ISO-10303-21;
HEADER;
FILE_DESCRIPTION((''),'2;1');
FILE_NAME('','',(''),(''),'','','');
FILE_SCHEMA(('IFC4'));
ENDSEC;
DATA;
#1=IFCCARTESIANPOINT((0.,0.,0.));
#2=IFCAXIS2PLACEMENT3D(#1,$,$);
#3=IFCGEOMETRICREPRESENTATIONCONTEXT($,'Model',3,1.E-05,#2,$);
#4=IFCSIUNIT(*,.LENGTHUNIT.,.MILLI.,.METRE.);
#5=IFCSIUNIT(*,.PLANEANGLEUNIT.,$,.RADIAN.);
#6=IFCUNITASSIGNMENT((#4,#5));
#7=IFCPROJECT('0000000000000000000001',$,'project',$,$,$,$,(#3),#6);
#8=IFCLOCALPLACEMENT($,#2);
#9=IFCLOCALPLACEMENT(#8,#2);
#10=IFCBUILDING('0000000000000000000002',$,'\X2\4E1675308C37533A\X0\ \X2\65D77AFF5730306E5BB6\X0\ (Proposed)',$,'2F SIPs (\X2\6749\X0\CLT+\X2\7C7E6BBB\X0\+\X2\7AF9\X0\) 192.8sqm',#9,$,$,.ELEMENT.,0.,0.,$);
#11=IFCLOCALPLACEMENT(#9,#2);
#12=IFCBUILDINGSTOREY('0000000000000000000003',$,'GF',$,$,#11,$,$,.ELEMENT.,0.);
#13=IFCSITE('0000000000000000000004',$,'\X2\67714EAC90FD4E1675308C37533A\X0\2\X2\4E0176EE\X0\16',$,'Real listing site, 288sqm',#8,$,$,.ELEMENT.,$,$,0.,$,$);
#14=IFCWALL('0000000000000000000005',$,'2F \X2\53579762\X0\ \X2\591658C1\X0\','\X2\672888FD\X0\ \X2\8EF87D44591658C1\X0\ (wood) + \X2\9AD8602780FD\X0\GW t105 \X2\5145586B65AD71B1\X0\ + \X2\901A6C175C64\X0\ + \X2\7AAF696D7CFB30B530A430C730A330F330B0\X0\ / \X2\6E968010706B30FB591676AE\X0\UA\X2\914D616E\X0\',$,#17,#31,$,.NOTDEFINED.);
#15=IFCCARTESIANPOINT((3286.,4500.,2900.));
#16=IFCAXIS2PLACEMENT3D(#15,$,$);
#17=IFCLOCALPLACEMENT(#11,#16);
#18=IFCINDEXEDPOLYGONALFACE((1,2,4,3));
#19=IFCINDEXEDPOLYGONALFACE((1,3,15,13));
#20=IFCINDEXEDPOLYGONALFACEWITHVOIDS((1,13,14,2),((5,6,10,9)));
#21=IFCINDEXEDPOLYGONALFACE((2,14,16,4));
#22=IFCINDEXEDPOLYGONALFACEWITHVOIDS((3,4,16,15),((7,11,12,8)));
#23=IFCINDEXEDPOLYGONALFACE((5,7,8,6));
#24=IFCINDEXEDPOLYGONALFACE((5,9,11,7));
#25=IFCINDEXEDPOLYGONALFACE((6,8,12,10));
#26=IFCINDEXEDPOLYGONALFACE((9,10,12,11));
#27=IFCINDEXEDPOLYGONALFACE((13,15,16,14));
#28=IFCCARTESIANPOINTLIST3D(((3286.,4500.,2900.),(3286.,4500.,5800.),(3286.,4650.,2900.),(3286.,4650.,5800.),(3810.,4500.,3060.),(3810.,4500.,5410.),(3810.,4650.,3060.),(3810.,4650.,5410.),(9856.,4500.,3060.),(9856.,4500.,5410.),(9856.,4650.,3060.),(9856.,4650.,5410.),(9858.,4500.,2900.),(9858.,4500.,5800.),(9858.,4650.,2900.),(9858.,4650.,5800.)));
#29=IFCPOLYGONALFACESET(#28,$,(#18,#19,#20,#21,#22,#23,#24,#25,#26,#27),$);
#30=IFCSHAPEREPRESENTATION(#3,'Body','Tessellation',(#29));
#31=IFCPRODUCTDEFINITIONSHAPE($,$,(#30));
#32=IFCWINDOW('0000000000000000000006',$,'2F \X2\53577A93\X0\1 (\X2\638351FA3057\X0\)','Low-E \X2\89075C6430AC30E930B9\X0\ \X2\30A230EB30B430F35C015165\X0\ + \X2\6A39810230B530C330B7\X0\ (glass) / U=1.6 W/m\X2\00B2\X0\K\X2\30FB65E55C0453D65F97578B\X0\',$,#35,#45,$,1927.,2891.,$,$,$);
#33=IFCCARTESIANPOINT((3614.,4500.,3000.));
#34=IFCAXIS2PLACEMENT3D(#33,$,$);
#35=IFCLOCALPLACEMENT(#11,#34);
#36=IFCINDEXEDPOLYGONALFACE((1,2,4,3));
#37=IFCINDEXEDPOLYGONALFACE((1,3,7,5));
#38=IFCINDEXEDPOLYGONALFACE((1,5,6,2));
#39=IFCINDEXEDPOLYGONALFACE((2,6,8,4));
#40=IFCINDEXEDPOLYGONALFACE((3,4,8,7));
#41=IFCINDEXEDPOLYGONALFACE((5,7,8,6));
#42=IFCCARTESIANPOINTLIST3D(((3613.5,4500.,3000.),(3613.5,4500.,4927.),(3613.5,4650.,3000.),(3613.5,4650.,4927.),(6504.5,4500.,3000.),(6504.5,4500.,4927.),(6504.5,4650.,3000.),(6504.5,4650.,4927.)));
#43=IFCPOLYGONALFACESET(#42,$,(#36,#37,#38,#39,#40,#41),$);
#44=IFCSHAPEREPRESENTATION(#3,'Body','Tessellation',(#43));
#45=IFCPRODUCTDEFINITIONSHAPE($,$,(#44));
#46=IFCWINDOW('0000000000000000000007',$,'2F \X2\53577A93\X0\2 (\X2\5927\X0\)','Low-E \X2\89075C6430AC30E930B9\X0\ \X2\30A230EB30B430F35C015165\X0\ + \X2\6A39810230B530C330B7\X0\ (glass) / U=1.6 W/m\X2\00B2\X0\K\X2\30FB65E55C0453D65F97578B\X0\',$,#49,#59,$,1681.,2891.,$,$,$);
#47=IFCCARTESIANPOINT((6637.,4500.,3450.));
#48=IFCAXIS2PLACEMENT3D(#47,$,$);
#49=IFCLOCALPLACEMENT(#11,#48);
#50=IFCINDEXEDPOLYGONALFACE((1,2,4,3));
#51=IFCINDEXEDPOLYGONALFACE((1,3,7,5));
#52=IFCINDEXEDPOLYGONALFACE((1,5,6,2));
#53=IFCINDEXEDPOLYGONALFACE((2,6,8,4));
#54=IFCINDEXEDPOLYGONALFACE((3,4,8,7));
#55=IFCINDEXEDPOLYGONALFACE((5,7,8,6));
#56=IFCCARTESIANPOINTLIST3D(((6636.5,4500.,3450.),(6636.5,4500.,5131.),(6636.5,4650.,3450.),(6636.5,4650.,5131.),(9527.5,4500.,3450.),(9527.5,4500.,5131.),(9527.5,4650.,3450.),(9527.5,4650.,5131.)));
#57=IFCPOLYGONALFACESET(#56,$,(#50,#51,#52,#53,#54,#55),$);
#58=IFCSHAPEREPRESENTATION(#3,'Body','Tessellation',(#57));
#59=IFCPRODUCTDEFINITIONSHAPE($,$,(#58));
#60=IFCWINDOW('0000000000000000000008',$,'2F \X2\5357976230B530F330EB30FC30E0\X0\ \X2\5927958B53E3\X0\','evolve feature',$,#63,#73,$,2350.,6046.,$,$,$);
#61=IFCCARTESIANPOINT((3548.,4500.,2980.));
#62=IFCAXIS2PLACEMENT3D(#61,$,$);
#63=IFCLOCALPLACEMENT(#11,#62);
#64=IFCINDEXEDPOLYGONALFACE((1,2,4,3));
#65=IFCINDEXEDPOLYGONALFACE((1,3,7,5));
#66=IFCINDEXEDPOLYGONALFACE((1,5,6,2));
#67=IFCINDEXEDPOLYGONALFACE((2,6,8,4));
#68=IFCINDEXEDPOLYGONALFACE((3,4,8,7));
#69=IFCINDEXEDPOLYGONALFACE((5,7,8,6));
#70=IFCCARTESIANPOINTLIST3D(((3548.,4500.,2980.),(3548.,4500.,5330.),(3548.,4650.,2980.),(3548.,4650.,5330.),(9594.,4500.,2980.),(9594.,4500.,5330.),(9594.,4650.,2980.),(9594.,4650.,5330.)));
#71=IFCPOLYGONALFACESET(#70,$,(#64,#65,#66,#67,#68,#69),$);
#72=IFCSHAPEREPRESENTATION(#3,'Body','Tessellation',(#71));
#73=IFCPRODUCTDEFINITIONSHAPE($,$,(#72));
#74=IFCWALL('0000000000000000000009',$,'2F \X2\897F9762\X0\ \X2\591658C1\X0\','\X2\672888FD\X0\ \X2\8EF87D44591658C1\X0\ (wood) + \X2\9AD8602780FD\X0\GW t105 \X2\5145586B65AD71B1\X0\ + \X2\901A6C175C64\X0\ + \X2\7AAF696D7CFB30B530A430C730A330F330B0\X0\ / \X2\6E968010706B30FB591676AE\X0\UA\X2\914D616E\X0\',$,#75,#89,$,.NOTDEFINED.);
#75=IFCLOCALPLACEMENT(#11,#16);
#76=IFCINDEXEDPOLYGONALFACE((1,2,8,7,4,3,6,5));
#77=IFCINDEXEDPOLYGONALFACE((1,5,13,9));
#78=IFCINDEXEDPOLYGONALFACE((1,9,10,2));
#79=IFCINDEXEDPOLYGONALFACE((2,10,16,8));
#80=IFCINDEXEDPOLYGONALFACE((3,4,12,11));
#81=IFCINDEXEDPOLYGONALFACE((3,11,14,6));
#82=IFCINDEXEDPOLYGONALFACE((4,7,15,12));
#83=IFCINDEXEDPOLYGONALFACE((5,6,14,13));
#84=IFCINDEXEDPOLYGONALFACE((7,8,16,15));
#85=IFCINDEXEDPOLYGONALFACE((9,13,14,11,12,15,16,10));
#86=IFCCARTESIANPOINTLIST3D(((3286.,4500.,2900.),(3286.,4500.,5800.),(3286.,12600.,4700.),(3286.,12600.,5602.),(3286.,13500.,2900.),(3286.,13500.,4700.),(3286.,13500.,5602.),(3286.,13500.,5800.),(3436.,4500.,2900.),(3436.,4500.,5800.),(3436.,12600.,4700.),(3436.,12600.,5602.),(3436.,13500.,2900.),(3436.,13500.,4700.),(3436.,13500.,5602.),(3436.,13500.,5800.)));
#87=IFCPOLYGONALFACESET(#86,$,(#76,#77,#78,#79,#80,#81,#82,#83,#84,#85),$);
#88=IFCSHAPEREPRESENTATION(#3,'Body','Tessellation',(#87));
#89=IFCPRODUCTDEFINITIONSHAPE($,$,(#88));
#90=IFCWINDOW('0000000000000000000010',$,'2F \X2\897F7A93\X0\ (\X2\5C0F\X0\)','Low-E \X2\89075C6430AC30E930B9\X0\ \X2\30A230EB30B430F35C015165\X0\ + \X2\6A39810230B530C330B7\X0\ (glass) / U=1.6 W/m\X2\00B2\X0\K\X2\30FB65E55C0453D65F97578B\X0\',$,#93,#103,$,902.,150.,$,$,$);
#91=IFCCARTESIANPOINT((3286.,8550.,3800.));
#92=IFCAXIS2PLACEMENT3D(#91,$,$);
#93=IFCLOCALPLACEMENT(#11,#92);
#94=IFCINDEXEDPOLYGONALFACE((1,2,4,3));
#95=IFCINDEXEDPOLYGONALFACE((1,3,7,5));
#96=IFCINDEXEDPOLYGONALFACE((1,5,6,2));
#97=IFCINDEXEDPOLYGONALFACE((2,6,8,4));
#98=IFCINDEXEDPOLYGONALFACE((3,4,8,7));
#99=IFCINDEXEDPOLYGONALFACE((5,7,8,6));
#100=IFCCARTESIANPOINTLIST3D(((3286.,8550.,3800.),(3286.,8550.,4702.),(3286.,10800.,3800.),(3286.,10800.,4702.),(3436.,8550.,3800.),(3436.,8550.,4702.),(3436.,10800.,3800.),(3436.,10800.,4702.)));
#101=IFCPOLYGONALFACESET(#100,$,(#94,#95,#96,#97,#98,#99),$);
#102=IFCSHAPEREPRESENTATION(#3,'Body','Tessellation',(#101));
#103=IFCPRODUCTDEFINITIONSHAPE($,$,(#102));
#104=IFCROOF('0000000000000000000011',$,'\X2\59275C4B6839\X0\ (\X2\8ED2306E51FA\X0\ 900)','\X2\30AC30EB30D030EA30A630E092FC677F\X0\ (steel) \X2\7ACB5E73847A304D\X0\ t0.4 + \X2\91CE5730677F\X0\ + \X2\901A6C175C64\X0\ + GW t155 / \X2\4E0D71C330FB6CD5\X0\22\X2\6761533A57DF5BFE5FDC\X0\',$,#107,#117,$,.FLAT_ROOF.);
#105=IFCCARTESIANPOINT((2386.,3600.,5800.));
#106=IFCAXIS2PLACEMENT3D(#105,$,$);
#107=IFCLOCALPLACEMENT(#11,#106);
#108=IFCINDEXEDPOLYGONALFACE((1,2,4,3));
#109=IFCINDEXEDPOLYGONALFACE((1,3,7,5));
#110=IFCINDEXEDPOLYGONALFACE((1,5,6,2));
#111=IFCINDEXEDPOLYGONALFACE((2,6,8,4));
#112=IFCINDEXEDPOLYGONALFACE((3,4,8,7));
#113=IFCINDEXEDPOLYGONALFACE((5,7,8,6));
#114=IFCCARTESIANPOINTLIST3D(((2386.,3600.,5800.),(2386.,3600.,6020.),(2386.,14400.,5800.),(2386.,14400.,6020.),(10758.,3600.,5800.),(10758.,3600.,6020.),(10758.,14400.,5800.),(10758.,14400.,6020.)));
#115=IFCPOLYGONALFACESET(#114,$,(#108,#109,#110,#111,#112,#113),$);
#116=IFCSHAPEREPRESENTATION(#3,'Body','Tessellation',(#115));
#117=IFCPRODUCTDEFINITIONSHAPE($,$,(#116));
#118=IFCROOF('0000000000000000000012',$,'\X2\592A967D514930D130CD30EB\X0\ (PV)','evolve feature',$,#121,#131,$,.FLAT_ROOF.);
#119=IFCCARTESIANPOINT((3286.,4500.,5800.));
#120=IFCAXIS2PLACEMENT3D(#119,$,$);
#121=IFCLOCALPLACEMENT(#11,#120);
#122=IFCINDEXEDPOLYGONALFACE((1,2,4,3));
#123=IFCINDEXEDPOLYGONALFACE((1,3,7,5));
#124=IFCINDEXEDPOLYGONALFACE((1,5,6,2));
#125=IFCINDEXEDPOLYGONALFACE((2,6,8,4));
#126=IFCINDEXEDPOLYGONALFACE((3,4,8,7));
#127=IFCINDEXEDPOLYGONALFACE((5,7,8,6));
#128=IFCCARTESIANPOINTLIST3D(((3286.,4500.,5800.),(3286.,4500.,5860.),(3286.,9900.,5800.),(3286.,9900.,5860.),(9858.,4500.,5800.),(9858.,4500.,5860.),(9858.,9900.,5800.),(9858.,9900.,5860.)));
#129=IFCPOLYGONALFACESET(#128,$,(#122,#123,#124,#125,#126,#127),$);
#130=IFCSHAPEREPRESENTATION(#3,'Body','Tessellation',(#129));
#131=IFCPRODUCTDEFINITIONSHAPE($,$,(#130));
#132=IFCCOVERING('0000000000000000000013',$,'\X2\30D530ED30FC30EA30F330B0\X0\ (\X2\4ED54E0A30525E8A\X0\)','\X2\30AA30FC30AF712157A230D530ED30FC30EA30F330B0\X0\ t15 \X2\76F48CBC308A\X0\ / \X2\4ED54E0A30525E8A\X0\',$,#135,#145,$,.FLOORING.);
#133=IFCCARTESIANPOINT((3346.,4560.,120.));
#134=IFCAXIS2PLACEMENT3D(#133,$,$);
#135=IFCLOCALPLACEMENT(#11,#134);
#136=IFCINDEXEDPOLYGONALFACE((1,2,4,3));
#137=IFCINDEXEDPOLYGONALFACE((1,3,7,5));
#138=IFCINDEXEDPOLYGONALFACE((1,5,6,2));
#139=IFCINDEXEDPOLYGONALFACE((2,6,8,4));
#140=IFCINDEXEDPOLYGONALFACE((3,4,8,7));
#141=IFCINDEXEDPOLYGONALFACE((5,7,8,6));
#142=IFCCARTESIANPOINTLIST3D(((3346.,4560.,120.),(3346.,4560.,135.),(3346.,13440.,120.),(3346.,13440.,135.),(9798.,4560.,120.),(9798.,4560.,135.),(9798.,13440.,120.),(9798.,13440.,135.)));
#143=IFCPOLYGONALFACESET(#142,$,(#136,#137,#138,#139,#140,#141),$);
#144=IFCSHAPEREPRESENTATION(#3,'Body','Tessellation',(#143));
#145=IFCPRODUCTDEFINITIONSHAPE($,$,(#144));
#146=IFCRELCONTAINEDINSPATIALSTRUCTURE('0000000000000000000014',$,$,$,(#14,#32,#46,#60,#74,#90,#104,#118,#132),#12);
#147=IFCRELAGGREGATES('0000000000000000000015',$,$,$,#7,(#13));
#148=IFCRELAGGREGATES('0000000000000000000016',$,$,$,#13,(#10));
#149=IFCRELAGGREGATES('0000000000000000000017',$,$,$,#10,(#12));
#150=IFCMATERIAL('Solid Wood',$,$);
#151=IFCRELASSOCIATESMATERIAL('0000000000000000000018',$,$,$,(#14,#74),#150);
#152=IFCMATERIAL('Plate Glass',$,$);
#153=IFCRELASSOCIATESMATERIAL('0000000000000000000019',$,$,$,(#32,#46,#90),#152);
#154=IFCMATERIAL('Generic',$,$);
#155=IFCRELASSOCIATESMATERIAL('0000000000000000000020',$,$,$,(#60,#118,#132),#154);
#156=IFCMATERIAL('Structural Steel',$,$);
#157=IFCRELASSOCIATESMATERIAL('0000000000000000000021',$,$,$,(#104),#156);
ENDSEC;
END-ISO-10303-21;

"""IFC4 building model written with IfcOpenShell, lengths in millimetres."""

from ifc_helpers import new_model, si_unit, frame, frame_2d, origin, place, context, project, spatial, rectangle, extrude, material, element, fill, save


model = new_model("IFC4")

# Units and contexts
model_context = context("Model", 3, precision=1e-05, world=origin())
ifc_project = project(units=[si_unit("LENGTHUNIT", "METRE", prefix="MILLI"), si_unit("PLANEANGLEUNIT", "RADIAN")], contexts=[model_context])

# Site, building, storey
site_placement = place(None, origin())
site = spatial("IfcSite", under=ifc_project, at=site_placement, Name="東京都世田谷区2丁目16", ObjectType="Real listing site, 288sqm", CompositionType="ELEMENT", RefElevation=0.0)
building_placement = place(site_placement, origin())
building = spatial("IfcBuilding", under=site, at=building_placement, Name="世田谷区 旗竿地の家 (Proposed)", ObjectType="2F SIPs (杉CLT+籾殻+竹) 192.8sqm", CompositionType="ELEMENT", ElevationOfRefHeight=0.0, ElevationOfTerrain=0.0)
storey_placement = place(building_placement, origin())
storey = spatial("IfcBuildingStorey", under=building, at=storey_placement, Name="GF", CompositionType="ELEMENT", Elevation=0.0)

# Shared definitions
ifc_material_1 = material(Name="Solid Wood")

# Shared definitions
ifc_material_2 = material(Name="Plate Glass")
ifc_material_3 = material(Name="Generic")

# Wall, openings, windows
wall_1_placement = place(storey_placement, frame((3286.0, 4500.0, 2900.0)))
wall_1 = element("IfcWall", 1, at=wall_1_placement, inside=storey, material=ifc_material_1, Name="2F 南面 外壁", Description="木製 軸組外壁 (wood) + 高性能GW t105 充填断熱 + 通気層 + 窯業系サイディング / 準耐火・外皮UA配慮", PredefinedType="NOTDEFINED", context=model_context, shape_type="SweptSolid", body=[
    extrude(rectangle(XDim=6572.0, YDim=150.0, at=frame_2d((3286.0, 75.0))), frame((3286.0, 4500.0, 2900.0)), (0.0, 0.0, 1.0), 2900.0),
])
opening_1_placement = place(storey_placement, frame((3614.0, 4500.0, 3000.0)))
opening_1 = element("IfcOpeningElement", 2, at=opening_1_placement, cuts=wall_1, PredefinedType="NOTDEFINED", context=model_context, shape_type="SweptSolid", body=[
    extrude(rectangle(XDim=2891.0, YDim=150.0, at=frame_2d((1445.0, 75.0))), frame((3614.0, 4500.0, 3000.0)), (0.0, 0.0, 1.0), 1927.0),
])
opening_2_placement = place(storey_placement, frame((6637.0, 4500.0, 3450.0)))
opening_2 = element("IfcOpeningElement", 3, at=opening_2_placement, cuts=wall_1, PredefinedType="NOTDEFINED", context=model_context, shape_type="SweptSolid", body=[
    extrude(rectangle(XDim=2891.0, YDim=150.0, at=frame_2d((1445.0, 75.0))), frame((6637.0, 4500.0, 3450.0)), (0.0, 0.0, 1.0), 1681.0),
])
opening_3_placement = place(storey_placement, frame((3548.0, 4500.0, 2980.0)))
opening_3 = element("IfcOpeningElement", 4, at=opening_3_placement, cuts=wall_1, PredefinedType="NOTDEFINED", context=model_context, shape_type="SweptSolid", body=[
    extrude(rectangle(XDim=6046.0, YDim=150.0, at=frame_2d((3023.0, 75.0))), frame((3548.0, 4500.0, 2980.0)), (0.0, 0.0, 1.0), 2350.0),
])
window_1_placement = place(storey_placement, frame((3614.0, 4500.0, 3000.0)))
window_1 = element("IfcWindow", 5, at=window_1_placement, inside=storey, material=ifc_material_2, Name="2F 南窓1 (掃出し)", Description="Low-E 複層ガラス アルゴン封入 + 樹脂サッシ (glass) / U=1.6 W/m²K・日射取得型", OverallHeight=1927.0, OverallWidth=2891.0, context=model_context, shape_type="SweptSolid", body=[
    extrude(rectangle(XDim=2891.0, YDim=150.0, at=frame_2d((1445.0, 75.0))), frame((3614.0, 4500.0, 3000.0)), (0.0, 0.0, 1.0), 1927.0),
])
fill(opening_1, window_1)
window_2_placement = place(storey_placement, frame((6637.0, 4500.0, 3450.0)))
window_2 = element("IfcWindow", 6, at=window_2_placement, inside=storey, material=ifc_material_2, Name="2F 南窓2 (大)", Description="Low-E 複層ガラス アルゴン封入 + 樹脂サッシ (glass) / U=1.6 W/m²K・日射取得型", OverallHeight=1681.0, OverallWidth=2891.0, context=model_context, shape_type="SweptSolid", body=[
    extrude(rectangle(XDim=2891.0, YDim=150.0, at=frame_2d((1445.0, 75.0))), frame((6637.0, 4500.0, 3450.0)), (0.0, 0.0, 1.0), 1681.0),
])
fill(opening_2, window_2)
window_3_placement = place(storey_placement, frame((3548.0, 4500.0, 2980.0)))
window_3 = element("IfcWindow", 7, at=window_3_placement, inside=storey, material=ifc_material_3, Name="2F 南面サンルーム 大開口", Description="evolve feature", OverallHeight=2350.0, OverallWidth=6046.0, context=model_context, shape_type="SweptSolid", body=[
    extrude(rectangle(XDim=6046.0, YDim=150.0, at=frame_2d((3023.0, 75.0))), frame((3548.0, 4500.0, 2980.0)), (0.0, 0.0, 1.0), 2350.0),
])
fill(opening_3, window_3)

# Wall, opening, window
wall_2_placement = place(storey_placement, frame((3286.0, 4500.0, 2900.0)))
wall_2 = element("IfcWall", 8, at=wall_2_placement, inside=storey, material=ifc_material_1, Name="2F 西面 外壁", Description="木製 軸組外壁 (wood) + 高性能GW t105 充填断熱 + 通気層 + 窯業系サイディング / 準耐火・外皮UA配慮", PredefinedType="NOTDEFINED", context=model_context, shape_type="SweptSolid", body=[
    extrude(rectangle(XDim=150.0, YDim=9000.0, at=frame_2d((75.0, 4500.0))), frame((3286.0, 4500.0, 2900.0)), (0.0, 0.0, 1.0), 2900.0),
])
opening_4_placement = place(storey_placement, frame((3286.0, 8550.0, 3800.0)))
opening_4 = element("IfcOpeningElement", 9, at=opening_4_placement, cuts=wall_2, PredefinedType="NOTDEFINED", context=model_context, shape_type="SweptSolid", body=[
    extrude(rectangle(XDim=150.0, YDim=2250.0, at=frame_2d((75.0, 1125.0))), frame((3286.0, 8550.0, 3800.0)), (0.0, 0.0, 1.0), 902.0),
])
window_4_placement = place(storey_placement, frame((3286.0, 8550.0, 3800.0)))
window_4 = element("IfcWindow", 10, at=window_4_placement, inside=storey, material=ifc_material_2, Name="2F 西窓 (小)", Description="Low-E 複層ガラス アルゴン封入 + 樹脂サッシ (glass) / U=1.6 W/m²K・日射取得型", OverallHeight=902.0, OverallWidth=150.0, context=model_context, shape_type="SweptSolid", body=[
    extrude(rectangle(XDim=150.0, YDim=2250.0, at=frame_2d((75.0, 1125.0))), frame((3286.0, 8550.0, 3800.0)), (0.0, 0.0, 1.0), 902.0),
])
fill(opening_4, window_4)

# Roofs
ifc_material_4 = material(Name="Structural Steel")
roof_1_placement = place(storey_placement, frame((2386.0, 3600.0, 5800.0)))
element("IfcRoof", 11, at=roof_1_placement, inside=storey, material=ifc_material_4, Name="大屋根 (軒の出 900)", Description="ガルバリウム鋼板 (steel) 立平葺き t0.4 + 野地板 + 通気層 + GW t155 / 不燃・法22条区域対応", PredefinedType="FLAT_ROOF", context=model_context, shape_type="SweptSolid", body=[
    extrude(rectangle(XDim=8372.0, YDim=10800.0, at=frame_2d((4186.0, 5400.0))), frame((2386.0, 3600.0, 5800.0)), (0.0, 0.0, 1.0), 220.0),
])
roof_2_placement = place(storey_placement, frame((3286.0, 4500.0, 5800.0)))
element("IfcRoof", 12, at=roof_2_placement, inside=storey, material=ifc_material_3, Name="太陽光パネル (PV)", Description="evolve feature", PredefinedType="FLAT_ROOF", context=model_context, shape_type="SweptSolid", body=[
    extrude(rectangle(XDim=6572.0, YDim=5400.0, at=frame_2d((3286.0, 2700.0))), frame((3286.0, 4500.0, 5800.0)), (0.0, 0.0, 1.0), 60.0),
])

# Covering
covering_placement = place(storey_placement, frame((3346.0, 4560.0, 120.0)))
element("IfcCovering", 13, at=covering_placement, inside=storey, material=ifc_material_3, Name="フローリング (仕上げ床)", Description="オーク無垢フローリング t15 直貼り / 仕上げ床", PredefinedType="FLOORING", context=model_context, shape_type="SweptSolid", body=[
    extrude(rectangle(XDim=6452.0, YDim=8880.0, at=frame_2d((3226.0, 4440.0))), frame((3346.0, 4560.0, 120.0)), (0.0, 0.0, 1.0), 15.0),
])

save(model, "model.ifc")
